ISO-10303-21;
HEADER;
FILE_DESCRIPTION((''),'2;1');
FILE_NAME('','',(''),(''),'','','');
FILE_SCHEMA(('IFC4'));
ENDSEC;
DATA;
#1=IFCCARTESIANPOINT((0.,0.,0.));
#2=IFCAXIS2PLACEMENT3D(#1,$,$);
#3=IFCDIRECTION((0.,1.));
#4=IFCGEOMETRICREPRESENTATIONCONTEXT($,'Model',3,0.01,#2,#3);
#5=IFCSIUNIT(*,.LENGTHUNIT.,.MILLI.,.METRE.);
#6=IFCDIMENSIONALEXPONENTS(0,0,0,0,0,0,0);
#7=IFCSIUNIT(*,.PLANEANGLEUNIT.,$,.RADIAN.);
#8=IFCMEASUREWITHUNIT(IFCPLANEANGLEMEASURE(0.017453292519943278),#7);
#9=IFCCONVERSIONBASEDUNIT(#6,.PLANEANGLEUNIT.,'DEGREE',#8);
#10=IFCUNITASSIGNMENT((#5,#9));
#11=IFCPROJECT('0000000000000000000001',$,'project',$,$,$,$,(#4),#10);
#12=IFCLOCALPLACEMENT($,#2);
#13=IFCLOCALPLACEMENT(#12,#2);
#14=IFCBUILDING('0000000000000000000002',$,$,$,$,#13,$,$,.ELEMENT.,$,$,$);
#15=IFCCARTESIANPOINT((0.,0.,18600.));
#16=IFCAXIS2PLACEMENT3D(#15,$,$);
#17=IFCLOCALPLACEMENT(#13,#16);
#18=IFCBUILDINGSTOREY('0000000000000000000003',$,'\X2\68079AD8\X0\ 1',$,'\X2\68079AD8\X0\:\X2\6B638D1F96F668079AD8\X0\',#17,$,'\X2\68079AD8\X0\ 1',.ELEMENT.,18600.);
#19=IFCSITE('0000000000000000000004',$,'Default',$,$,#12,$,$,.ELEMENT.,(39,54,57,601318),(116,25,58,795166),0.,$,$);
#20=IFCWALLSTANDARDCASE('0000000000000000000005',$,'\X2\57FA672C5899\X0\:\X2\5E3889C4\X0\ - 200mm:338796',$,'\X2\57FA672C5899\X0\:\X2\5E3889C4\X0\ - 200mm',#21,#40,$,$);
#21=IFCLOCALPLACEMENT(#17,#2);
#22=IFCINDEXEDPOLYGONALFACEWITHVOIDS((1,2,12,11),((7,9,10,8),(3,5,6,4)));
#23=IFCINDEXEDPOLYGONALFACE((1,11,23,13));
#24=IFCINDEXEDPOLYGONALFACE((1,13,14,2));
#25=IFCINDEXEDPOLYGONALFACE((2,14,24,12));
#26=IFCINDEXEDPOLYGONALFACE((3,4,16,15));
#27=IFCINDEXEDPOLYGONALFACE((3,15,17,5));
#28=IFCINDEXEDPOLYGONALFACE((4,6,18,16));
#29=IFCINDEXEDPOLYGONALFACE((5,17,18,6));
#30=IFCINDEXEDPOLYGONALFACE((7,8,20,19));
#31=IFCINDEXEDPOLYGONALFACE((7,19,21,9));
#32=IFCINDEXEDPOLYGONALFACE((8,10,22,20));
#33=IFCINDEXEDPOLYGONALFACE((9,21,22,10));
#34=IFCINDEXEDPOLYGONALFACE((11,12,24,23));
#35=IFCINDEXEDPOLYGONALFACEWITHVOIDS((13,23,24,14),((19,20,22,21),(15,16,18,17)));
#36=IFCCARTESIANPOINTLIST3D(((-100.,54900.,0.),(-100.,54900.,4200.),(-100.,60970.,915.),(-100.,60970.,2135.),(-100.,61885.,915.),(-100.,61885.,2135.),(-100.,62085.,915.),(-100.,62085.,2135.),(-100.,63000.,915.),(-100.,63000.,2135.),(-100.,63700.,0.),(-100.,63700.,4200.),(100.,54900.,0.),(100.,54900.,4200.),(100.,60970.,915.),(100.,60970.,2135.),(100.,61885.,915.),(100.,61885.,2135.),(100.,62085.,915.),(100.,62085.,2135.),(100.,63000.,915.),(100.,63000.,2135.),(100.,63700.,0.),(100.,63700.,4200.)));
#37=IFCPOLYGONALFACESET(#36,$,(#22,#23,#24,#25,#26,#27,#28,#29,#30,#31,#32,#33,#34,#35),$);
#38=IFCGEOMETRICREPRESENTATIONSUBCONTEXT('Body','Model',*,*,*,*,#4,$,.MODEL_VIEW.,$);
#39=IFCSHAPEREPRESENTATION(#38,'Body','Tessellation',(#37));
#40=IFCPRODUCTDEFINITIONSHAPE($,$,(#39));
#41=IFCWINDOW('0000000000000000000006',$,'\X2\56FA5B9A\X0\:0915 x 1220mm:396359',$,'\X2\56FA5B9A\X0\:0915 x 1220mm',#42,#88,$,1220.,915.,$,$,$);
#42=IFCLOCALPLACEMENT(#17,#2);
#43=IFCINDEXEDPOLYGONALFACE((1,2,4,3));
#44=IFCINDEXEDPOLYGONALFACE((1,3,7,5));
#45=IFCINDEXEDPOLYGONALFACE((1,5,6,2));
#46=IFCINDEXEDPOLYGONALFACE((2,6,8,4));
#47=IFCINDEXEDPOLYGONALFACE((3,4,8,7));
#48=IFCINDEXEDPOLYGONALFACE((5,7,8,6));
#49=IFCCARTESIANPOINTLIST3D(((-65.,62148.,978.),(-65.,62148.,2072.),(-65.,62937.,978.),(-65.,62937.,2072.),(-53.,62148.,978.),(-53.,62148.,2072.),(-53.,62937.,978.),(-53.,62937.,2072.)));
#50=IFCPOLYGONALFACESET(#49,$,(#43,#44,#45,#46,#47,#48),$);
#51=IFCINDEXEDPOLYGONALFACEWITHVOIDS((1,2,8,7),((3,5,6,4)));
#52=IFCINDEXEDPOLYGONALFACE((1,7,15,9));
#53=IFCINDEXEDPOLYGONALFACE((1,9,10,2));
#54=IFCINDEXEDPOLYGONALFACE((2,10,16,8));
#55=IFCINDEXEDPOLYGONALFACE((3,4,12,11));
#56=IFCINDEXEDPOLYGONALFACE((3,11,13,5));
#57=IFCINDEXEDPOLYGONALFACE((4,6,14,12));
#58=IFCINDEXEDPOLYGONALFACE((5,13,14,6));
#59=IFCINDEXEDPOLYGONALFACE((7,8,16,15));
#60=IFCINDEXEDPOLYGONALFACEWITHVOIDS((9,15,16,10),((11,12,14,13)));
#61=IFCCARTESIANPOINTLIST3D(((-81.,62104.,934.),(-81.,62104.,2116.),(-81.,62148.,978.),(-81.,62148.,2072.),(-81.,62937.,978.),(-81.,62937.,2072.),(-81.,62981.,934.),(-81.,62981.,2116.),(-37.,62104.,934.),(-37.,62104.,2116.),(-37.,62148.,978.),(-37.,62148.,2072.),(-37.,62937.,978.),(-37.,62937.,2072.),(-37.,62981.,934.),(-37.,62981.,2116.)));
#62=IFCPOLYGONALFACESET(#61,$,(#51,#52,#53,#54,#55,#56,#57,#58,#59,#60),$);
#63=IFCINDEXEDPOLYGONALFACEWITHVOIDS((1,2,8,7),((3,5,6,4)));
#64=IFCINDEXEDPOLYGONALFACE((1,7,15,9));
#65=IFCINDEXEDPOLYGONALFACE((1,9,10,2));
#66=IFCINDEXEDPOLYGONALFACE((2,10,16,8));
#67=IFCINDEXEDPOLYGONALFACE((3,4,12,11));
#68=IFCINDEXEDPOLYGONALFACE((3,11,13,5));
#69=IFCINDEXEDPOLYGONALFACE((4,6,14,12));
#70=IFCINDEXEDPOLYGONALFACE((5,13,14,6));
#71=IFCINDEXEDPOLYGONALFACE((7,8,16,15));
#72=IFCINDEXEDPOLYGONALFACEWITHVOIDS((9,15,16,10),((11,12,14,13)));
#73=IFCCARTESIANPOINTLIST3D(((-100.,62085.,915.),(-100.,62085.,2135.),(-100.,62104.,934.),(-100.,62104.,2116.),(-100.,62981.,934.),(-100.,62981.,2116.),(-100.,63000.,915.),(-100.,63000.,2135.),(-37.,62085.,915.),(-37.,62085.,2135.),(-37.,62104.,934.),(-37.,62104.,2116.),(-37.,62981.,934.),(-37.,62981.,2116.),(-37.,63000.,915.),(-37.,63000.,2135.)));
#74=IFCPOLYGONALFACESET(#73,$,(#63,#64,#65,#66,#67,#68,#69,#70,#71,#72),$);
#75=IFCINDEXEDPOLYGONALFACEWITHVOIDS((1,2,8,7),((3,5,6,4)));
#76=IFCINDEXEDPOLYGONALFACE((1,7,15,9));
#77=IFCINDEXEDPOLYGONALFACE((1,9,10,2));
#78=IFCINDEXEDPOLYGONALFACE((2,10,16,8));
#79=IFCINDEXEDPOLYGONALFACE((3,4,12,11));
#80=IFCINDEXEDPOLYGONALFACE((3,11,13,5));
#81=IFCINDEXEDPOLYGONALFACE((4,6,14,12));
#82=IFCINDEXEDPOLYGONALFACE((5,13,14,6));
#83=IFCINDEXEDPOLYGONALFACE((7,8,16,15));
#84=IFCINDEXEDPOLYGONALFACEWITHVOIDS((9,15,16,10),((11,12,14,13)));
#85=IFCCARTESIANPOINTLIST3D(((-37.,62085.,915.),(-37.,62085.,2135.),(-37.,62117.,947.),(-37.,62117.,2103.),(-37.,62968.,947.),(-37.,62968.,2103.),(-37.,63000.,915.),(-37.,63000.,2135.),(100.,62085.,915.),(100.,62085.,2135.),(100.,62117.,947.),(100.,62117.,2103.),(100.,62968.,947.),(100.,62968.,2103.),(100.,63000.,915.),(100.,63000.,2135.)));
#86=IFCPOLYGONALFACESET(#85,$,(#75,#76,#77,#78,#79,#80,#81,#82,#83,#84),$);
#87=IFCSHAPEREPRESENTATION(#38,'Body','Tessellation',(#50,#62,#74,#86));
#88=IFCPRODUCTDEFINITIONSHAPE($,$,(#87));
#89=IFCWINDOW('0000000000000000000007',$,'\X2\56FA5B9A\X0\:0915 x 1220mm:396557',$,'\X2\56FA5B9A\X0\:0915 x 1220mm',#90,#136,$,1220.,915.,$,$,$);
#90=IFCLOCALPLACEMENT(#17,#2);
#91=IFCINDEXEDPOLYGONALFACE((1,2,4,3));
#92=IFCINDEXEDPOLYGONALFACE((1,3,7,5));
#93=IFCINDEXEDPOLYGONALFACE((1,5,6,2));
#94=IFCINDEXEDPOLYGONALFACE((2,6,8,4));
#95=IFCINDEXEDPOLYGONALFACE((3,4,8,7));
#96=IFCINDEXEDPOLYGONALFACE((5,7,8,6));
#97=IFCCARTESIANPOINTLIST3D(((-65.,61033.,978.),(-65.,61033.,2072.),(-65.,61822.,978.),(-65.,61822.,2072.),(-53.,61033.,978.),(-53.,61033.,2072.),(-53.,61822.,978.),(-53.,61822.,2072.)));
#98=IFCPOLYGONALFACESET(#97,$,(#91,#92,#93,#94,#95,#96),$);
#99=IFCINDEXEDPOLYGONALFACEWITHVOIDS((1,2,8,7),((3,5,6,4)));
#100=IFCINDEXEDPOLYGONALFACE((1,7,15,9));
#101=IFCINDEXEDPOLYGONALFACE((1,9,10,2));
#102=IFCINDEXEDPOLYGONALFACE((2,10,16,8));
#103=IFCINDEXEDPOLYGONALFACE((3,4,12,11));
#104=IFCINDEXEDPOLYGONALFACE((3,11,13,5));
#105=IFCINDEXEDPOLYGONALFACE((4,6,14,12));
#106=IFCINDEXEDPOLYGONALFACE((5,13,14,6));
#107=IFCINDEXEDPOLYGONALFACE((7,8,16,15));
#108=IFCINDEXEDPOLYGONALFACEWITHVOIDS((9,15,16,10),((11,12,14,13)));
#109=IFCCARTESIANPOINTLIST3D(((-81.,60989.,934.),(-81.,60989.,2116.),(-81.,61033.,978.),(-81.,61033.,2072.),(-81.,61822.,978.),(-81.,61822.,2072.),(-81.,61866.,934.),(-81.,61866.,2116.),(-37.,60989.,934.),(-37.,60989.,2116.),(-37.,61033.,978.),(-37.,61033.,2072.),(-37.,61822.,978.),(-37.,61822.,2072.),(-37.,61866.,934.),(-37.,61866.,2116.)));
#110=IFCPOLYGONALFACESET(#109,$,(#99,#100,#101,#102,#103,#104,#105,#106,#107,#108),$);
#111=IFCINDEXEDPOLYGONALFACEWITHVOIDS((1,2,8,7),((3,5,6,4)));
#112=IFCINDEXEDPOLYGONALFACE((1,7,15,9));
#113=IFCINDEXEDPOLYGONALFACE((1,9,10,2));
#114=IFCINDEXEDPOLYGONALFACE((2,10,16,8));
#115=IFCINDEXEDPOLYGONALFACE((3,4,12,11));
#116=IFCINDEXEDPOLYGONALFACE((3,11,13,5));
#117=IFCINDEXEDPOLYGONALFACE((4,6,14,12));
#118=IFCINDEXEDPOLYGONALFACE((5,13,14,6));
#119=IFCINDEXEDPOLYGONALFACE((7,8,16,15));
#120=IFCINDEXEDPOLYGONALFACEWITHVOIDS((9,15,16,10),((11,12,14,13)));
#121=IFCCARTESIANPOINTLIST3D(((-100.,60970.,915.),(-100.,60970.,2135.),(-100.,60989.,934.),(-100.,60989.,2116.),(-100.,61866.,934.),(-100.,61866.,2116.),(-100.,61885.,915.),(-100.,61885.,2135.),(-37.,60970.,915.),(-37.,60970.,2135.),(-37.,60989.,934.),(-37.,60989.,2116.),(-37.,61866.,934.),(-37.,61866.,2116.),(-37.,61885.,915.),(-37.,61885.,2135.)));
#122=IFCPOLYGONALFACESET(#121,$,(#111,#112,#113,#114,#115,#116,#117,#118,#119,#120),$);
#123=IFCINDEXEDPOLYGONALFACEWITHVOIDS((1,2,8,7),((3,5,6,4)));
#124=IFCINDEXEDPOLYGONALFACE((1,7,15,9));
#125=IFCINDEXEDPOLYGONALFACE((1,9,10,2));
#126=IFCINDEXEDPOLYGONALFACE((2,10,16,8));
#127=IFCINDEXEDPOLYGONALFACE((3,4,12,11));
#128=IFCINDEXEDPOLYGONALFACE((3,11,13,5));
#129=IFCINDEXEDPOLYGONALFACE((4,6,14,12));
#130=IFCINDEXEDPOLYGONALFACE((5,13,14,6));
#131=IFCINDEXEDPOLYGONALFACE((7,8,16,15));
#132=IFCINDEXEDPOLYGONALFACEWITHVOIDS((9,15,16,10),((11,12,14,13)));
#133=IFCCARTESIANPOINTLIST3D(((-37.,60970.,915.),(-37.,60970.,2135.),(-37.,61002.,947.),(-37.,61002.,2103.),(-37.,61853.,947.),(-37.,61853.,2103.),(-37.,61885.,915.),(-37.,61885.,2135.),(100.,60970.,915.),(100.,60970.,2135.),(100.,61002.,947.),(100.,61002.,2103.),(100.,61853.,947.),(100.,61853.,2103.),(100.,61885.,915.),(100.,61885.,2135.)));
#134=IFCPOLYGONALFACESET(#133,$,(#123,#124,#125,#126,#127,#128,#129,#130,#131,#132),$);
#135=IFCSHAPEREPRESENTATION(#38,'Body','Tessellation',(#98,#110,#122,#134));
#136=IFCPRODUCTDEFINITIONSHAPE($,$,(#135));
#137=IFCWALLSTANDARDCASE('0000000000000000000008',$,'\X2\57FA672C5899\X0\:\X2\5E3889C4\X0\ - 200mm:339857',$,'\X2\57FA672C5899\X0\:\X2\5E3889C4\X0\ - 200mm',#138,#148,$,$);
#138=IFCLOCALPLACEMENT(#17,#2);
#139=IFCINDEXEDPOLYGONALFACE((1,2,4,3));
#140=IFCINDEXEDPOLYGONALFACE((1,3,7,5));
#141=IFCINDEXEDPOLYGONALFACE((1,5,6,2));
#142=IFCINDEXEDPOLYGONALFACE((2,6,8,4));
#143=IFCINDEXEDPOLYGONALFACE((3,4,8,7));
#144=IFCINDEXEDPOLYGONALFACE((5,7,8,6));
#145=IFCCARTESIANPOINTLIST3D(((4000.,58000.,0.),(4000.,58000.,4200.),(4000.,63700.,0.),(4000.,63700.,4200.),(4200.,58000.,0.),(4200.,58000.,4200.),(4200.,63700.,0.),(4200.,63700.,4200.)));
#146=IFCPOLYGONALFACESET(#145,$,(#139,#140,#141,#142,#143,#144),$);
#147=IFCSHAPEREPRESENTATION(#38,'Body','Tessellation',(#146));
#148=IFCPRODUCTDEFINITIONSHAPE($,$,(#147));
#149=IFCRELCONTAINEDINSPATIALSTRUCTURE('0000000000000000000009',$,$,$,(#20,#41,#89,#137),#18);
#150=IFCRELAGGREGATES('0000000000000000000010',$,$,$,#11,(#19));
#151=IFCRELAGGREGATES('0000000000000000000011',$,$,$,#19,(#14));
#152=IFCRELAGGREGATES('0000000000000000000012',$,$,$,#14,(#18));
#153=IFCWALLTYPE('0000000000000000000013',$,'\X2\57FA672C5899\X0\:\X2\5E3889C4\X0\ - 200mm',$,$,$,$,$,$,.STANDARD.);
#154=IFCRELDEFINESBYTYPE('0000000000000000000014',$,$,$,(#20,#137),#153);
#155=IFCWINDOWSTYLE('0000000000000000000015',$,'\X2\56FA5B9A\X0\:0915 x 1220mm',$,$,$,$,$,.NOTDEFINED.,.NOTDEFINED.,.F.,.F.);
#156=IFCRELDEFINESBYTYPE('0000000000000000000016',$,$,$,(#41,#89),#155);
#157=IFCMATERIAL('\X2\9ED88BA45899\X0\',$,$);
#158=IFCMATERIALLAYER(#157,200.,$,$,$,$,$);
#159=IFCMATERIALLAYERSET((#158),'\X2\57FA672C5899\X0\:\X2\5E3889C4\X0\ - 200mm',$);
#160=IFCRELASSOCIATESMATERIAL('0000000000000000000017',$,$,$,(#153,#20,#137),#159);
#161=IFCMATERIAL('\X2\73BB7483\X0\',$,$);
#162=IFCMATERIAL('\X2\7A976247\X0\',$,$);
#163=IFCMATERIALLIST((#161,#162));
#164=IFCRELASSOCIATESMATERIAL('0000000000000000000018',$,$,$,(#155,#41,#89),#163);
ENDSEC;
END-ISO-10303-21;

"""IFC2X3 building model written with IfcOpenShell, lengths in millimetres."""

from ifc_helpers import new_model, entity, si_unit, converted_unit, direction, frame, frame_2d, origin, place, context, subcontext, project, spatial, polyline, rectangle, outline, extrude, source, transform, mapped, material, material_list, layer, layer_set, layer_usage, type_object, type_shapes, element, fill, save


model = new_model("IFC2X3")

# Units and contexts
model_context = context("Model", 3, precision=0.01, world=origin(), true_north=direction((0.0, 1.0)))
body_context = subcontext(model_context, "Body", "Model", "MODEL_VIEW")
ifc_project = project(units=[si_unit("LENGTHUNIT", "METRE", prefix="MILLI"), converted_unit("PLANEANGLEUNIT", "DEGREE", entity("IfcPlaneAngleMeasure", 0.017453292519943278), si_unit("PLANEANGLEUNIT", "RADIAN"), dimensions=[0, 0, 0, 0, 0, 0, 0])], contexts=[model_context])

# Site, building, storey
site_placement = place(None, origin())
site = spatial("IfcSite", under=ifc_project, at=site_placement, Name="Default", CompositionType="ELEMENT", RefLatitude=(39, 54, 57, 601318), RefLongitude=(116, 25, 58, 795166), RefElevation=0.0)
building_placement = place(site_placement, origin())
building = spatial("IfcBuilding", under=site, at=building_placement, CompositionType="ELEMENT")
storey_placement = place(building_placement, frame((0.0, 0.0, 18600.0)))
storey = spatial("IfcBuildingStorey", under=building, at=storey_placement, Name="标高 1", ObjectType="标高:正负零标高", LongName="标高 1", CompositionType="ELEMENT", Elevation=18600.0)

# Shared definitions
ifc_material_1 = material(Name="默认墙")
ifc_layer = layer(ifc_material_1, 200.0)
ifc_layer_set = layer_set([ifc_layer], Name="基本墙:常规 - 200mm")
wall_type = type_object("IfcWallType", Name="基本墙:常规 - 200mm", PredefinedType="STANDARD", material=ifc_layer_set)
ifc_material_2 = material(Name="玻璃")
ifc_material_3 = material(Name="窗扇")
ifc_material_list_1 = material_list([ifc_material_2, ifc_material_3])
window_style = type_object("IfcWindowStyle", Name="固定:0915 x 1220mm", ConstructionType="NOTDEFINED", OperationType="NOTDEFINED", ParameterTakesPrecedence=False, Sizeable=False, material=ifc_material_list_1)
shared_shape_1 = source(origin(), body_context, "Body", "SweptSolid", [
    extrude(rectangle(XDim=12.0, YDim=789.0, at=frame_2d((0.0, 0.0), x_axis=(1.0, 0.0))), frame((457.5, 159.0, 63.0), z_axis=(0.0, 0.0, 1.0), x_axis=(0.0, -1.0, 0.0)), (0.0, 0.0, 1.0), 1094.0),
    extrude(outline(polyline([(-438.5, -591.0), (438.5, -591.0), (438.5, 591.0), (-438.5, 591.0), (-438.5, -591.0)]), holes=[polyline([(-394.5, -547.0), (-394.5, 547.0), (394.5, 547.0), (394.5, -547.0), (-394.5, -547.0)])]), frame((457.5, 137.0, 610.0), z_axis=(0.0, 1.0, 0.0), x_axis=(1.0, 0.0, 0.0)), (0.0, 0.0, 1.0), 44.0),
    extrude(outline(polyline([(-457.5, -610.0), (457.5, -610.0), (457.5, 610.0), (-457.5, 610.0), (-457.5, -610.0)]), holes=[polyline([(-438.5, -591.0), (-438.5, 591.0), (438.5, 591.0), (438.5, -591.0), (-438.5, -591.0)])]), frame((457.5, 137.0, 610.0), z_axis=(0.0, 1.0, 0.0), x_axis=(1.0, 0.0, 0.0)), (0.0, 0.0, 1.0), 63.0),
    extrude(outline(polyline([(-457.5, -610.0), (457.5, -610.0), (457.5, 610.0), (-457.5, 610.0), (-457.5, -610.0)]), holes=[polyline([(-425.5, -578.0), (-425.5, 578.0), (425.5, 578.0), (425.5, -578.0), (-425.5, -578.0)])]), frame((457.5, 0.0, 610.0), z_axis=(0.0, 1.0, 0.0), x_axis=(1.0, 0.0, 0.0)), (0.0, 0.0, 1.0), 137.0),
])
type_shapes(window_style, [shared_shape_1])

# Wall, openings, windows
ifc_layer_usage_1 = layer_usage(ifc_layer_set, "AXIS2", "NEGATIVE", 100.0)
wall_1_placement = place(storey_placement, frame((0.0, 63700.0, 0.0), z_axis=(0.0, 0.0, 1.0), x_axis=(0.0, -1.0, 0.0)))
wall_1 = element("IfcWallStandardCase", 1, at=wall_1_placement, inside=storey, type_object=wall_type, material=ifc_layer_usage_1, Name="基本墙:常规 - 200mm:338796", ObjectType="基本墙:常规 - 200mm", context=body_context, shape_type="SweptSolid", body=[
    extrude(rectangle(XDim=8800.0, YDim=200.0, at=frame_2d((4400.0, 0.0), x_axis=(-1.0, 0.0))), origin(), (0.0, 0.0, 1.0), 4200.0),
])
opening_1_placement = place(wall_1_placement, frame((1615.0, 100.0, 915.0)))
opening_1 = element("IfcOpeningElement", 2, at=opening_1_placement, cuts=wall_1, ObjectType="Opening", context=body_context, shape_type="SweptSolid", body=[
    extrude(rectangle(XDim=1220.0, YDim=915.0, at=frame_2d((610.0, 457.5), x_axis=(1.0, 0.0))), frame((0.0, 0.0, 0.0), z_axis=(0.0, -1.0, 0.0), x_axis=(0.0, 0.0, 1.0)), (0.0, 0.0, 1.0), 200.0),
])
opening_2_placement = place(wall_1_placement, frame((2730.0, 100.0, 915.0)))
opening_2 = element("IfcOpeningElement", 3, at=opening_2_placement, cuts=wall_1, ObjectType="Opening", context=body_context, shape_type="SweptSolid", body=[
    extrude(rectangle(XDim=1220.0, YDim=915.0, at=frame_2d((610.0, 457.5), x_axis=(1.0, 0.0))), frame((0.0, 0.0, 0.0), z_axis=(0.0, -1.0, 0.0), x_axis=(0.0, 0.0, 1.0)), (0.0, 0.0, 1.0), 200.0),
])
window_1_placement = place(opening_1_placement, frame((0.0, 0.0, 0.0), z_axis=(0.0, 0.0, 1.0), x_axis=(-1.0, 0.0, 0.0)))
window_1 = element("IfcWindow", 4, at=window_1_placement, inside=storey, type_object=window_style, material=ifc_material_list_1, Name="固定:0915 x 1220mm:396359", ObjectType="固定:0915 x 1220mm", OverallHeight=1220.0, OverallWidth=915.0, context=body_context, shape_type="MappedRepresentation", body=[
    mapped(shared_shape_1, transform((0.0, 0.0, 0.0), scale=1.0)),
])
fill(opening_1, window_1)
window_2_placement = place(opening_2_placement, frame((0.0, 0.0, 0.0), z_axis=(0.0, 0.0, 1.0), x_axis=(-1.0, 0.0, 0.0)))
window_2 = element("IfcWindow", 5, at=window_2_placement, inside=storey, type_object=window_style, material=ifc_material_list_1, Name="固定:0915 x 1220mm:396557", ObjectType="固定:0915 x 1220mm", OverallHeight=1220.0, OverallWidth=915.0, context=body_context, shape_type="MappedRepresentation", body=[
    mapped(shared_shape_1, transform((0.0, 0.0, 0.0), scale=1.0)),
])
fill(opening_2, window_2)

# Wall
ifc_layer_usage_2 = layer_usage(ifc_layer_set, "AXIS2", "NEGATIVE", 100.0)
wall_2_placement = place(storey_placement, frame((4100.0, 58000.0, 0.0), z_axis=(0.0, 0.0, 1.0), x_axis=(0.0, 1.0, 0.0)))
element("IfcWallStandardCase", 6, at=wall_2_placement, inside=storey, type_object=wall_type, material=ifc_layer_usage_2, Name="基本墙:常规 - 200mm:339857", ObjectType="基本墙:常规 - 200mm", context=body_context, shape_type="SweptSolid", body=[
    extrude(rectangle(XDim=5700.0, YDim=200.0, at=frame_2d((2850.0, 0.0), x_axis=(-1.0, 0.0))), origin(), (0.0, 0.0, 1.0), 4200.0),
])

save(model, "model.ifc")
